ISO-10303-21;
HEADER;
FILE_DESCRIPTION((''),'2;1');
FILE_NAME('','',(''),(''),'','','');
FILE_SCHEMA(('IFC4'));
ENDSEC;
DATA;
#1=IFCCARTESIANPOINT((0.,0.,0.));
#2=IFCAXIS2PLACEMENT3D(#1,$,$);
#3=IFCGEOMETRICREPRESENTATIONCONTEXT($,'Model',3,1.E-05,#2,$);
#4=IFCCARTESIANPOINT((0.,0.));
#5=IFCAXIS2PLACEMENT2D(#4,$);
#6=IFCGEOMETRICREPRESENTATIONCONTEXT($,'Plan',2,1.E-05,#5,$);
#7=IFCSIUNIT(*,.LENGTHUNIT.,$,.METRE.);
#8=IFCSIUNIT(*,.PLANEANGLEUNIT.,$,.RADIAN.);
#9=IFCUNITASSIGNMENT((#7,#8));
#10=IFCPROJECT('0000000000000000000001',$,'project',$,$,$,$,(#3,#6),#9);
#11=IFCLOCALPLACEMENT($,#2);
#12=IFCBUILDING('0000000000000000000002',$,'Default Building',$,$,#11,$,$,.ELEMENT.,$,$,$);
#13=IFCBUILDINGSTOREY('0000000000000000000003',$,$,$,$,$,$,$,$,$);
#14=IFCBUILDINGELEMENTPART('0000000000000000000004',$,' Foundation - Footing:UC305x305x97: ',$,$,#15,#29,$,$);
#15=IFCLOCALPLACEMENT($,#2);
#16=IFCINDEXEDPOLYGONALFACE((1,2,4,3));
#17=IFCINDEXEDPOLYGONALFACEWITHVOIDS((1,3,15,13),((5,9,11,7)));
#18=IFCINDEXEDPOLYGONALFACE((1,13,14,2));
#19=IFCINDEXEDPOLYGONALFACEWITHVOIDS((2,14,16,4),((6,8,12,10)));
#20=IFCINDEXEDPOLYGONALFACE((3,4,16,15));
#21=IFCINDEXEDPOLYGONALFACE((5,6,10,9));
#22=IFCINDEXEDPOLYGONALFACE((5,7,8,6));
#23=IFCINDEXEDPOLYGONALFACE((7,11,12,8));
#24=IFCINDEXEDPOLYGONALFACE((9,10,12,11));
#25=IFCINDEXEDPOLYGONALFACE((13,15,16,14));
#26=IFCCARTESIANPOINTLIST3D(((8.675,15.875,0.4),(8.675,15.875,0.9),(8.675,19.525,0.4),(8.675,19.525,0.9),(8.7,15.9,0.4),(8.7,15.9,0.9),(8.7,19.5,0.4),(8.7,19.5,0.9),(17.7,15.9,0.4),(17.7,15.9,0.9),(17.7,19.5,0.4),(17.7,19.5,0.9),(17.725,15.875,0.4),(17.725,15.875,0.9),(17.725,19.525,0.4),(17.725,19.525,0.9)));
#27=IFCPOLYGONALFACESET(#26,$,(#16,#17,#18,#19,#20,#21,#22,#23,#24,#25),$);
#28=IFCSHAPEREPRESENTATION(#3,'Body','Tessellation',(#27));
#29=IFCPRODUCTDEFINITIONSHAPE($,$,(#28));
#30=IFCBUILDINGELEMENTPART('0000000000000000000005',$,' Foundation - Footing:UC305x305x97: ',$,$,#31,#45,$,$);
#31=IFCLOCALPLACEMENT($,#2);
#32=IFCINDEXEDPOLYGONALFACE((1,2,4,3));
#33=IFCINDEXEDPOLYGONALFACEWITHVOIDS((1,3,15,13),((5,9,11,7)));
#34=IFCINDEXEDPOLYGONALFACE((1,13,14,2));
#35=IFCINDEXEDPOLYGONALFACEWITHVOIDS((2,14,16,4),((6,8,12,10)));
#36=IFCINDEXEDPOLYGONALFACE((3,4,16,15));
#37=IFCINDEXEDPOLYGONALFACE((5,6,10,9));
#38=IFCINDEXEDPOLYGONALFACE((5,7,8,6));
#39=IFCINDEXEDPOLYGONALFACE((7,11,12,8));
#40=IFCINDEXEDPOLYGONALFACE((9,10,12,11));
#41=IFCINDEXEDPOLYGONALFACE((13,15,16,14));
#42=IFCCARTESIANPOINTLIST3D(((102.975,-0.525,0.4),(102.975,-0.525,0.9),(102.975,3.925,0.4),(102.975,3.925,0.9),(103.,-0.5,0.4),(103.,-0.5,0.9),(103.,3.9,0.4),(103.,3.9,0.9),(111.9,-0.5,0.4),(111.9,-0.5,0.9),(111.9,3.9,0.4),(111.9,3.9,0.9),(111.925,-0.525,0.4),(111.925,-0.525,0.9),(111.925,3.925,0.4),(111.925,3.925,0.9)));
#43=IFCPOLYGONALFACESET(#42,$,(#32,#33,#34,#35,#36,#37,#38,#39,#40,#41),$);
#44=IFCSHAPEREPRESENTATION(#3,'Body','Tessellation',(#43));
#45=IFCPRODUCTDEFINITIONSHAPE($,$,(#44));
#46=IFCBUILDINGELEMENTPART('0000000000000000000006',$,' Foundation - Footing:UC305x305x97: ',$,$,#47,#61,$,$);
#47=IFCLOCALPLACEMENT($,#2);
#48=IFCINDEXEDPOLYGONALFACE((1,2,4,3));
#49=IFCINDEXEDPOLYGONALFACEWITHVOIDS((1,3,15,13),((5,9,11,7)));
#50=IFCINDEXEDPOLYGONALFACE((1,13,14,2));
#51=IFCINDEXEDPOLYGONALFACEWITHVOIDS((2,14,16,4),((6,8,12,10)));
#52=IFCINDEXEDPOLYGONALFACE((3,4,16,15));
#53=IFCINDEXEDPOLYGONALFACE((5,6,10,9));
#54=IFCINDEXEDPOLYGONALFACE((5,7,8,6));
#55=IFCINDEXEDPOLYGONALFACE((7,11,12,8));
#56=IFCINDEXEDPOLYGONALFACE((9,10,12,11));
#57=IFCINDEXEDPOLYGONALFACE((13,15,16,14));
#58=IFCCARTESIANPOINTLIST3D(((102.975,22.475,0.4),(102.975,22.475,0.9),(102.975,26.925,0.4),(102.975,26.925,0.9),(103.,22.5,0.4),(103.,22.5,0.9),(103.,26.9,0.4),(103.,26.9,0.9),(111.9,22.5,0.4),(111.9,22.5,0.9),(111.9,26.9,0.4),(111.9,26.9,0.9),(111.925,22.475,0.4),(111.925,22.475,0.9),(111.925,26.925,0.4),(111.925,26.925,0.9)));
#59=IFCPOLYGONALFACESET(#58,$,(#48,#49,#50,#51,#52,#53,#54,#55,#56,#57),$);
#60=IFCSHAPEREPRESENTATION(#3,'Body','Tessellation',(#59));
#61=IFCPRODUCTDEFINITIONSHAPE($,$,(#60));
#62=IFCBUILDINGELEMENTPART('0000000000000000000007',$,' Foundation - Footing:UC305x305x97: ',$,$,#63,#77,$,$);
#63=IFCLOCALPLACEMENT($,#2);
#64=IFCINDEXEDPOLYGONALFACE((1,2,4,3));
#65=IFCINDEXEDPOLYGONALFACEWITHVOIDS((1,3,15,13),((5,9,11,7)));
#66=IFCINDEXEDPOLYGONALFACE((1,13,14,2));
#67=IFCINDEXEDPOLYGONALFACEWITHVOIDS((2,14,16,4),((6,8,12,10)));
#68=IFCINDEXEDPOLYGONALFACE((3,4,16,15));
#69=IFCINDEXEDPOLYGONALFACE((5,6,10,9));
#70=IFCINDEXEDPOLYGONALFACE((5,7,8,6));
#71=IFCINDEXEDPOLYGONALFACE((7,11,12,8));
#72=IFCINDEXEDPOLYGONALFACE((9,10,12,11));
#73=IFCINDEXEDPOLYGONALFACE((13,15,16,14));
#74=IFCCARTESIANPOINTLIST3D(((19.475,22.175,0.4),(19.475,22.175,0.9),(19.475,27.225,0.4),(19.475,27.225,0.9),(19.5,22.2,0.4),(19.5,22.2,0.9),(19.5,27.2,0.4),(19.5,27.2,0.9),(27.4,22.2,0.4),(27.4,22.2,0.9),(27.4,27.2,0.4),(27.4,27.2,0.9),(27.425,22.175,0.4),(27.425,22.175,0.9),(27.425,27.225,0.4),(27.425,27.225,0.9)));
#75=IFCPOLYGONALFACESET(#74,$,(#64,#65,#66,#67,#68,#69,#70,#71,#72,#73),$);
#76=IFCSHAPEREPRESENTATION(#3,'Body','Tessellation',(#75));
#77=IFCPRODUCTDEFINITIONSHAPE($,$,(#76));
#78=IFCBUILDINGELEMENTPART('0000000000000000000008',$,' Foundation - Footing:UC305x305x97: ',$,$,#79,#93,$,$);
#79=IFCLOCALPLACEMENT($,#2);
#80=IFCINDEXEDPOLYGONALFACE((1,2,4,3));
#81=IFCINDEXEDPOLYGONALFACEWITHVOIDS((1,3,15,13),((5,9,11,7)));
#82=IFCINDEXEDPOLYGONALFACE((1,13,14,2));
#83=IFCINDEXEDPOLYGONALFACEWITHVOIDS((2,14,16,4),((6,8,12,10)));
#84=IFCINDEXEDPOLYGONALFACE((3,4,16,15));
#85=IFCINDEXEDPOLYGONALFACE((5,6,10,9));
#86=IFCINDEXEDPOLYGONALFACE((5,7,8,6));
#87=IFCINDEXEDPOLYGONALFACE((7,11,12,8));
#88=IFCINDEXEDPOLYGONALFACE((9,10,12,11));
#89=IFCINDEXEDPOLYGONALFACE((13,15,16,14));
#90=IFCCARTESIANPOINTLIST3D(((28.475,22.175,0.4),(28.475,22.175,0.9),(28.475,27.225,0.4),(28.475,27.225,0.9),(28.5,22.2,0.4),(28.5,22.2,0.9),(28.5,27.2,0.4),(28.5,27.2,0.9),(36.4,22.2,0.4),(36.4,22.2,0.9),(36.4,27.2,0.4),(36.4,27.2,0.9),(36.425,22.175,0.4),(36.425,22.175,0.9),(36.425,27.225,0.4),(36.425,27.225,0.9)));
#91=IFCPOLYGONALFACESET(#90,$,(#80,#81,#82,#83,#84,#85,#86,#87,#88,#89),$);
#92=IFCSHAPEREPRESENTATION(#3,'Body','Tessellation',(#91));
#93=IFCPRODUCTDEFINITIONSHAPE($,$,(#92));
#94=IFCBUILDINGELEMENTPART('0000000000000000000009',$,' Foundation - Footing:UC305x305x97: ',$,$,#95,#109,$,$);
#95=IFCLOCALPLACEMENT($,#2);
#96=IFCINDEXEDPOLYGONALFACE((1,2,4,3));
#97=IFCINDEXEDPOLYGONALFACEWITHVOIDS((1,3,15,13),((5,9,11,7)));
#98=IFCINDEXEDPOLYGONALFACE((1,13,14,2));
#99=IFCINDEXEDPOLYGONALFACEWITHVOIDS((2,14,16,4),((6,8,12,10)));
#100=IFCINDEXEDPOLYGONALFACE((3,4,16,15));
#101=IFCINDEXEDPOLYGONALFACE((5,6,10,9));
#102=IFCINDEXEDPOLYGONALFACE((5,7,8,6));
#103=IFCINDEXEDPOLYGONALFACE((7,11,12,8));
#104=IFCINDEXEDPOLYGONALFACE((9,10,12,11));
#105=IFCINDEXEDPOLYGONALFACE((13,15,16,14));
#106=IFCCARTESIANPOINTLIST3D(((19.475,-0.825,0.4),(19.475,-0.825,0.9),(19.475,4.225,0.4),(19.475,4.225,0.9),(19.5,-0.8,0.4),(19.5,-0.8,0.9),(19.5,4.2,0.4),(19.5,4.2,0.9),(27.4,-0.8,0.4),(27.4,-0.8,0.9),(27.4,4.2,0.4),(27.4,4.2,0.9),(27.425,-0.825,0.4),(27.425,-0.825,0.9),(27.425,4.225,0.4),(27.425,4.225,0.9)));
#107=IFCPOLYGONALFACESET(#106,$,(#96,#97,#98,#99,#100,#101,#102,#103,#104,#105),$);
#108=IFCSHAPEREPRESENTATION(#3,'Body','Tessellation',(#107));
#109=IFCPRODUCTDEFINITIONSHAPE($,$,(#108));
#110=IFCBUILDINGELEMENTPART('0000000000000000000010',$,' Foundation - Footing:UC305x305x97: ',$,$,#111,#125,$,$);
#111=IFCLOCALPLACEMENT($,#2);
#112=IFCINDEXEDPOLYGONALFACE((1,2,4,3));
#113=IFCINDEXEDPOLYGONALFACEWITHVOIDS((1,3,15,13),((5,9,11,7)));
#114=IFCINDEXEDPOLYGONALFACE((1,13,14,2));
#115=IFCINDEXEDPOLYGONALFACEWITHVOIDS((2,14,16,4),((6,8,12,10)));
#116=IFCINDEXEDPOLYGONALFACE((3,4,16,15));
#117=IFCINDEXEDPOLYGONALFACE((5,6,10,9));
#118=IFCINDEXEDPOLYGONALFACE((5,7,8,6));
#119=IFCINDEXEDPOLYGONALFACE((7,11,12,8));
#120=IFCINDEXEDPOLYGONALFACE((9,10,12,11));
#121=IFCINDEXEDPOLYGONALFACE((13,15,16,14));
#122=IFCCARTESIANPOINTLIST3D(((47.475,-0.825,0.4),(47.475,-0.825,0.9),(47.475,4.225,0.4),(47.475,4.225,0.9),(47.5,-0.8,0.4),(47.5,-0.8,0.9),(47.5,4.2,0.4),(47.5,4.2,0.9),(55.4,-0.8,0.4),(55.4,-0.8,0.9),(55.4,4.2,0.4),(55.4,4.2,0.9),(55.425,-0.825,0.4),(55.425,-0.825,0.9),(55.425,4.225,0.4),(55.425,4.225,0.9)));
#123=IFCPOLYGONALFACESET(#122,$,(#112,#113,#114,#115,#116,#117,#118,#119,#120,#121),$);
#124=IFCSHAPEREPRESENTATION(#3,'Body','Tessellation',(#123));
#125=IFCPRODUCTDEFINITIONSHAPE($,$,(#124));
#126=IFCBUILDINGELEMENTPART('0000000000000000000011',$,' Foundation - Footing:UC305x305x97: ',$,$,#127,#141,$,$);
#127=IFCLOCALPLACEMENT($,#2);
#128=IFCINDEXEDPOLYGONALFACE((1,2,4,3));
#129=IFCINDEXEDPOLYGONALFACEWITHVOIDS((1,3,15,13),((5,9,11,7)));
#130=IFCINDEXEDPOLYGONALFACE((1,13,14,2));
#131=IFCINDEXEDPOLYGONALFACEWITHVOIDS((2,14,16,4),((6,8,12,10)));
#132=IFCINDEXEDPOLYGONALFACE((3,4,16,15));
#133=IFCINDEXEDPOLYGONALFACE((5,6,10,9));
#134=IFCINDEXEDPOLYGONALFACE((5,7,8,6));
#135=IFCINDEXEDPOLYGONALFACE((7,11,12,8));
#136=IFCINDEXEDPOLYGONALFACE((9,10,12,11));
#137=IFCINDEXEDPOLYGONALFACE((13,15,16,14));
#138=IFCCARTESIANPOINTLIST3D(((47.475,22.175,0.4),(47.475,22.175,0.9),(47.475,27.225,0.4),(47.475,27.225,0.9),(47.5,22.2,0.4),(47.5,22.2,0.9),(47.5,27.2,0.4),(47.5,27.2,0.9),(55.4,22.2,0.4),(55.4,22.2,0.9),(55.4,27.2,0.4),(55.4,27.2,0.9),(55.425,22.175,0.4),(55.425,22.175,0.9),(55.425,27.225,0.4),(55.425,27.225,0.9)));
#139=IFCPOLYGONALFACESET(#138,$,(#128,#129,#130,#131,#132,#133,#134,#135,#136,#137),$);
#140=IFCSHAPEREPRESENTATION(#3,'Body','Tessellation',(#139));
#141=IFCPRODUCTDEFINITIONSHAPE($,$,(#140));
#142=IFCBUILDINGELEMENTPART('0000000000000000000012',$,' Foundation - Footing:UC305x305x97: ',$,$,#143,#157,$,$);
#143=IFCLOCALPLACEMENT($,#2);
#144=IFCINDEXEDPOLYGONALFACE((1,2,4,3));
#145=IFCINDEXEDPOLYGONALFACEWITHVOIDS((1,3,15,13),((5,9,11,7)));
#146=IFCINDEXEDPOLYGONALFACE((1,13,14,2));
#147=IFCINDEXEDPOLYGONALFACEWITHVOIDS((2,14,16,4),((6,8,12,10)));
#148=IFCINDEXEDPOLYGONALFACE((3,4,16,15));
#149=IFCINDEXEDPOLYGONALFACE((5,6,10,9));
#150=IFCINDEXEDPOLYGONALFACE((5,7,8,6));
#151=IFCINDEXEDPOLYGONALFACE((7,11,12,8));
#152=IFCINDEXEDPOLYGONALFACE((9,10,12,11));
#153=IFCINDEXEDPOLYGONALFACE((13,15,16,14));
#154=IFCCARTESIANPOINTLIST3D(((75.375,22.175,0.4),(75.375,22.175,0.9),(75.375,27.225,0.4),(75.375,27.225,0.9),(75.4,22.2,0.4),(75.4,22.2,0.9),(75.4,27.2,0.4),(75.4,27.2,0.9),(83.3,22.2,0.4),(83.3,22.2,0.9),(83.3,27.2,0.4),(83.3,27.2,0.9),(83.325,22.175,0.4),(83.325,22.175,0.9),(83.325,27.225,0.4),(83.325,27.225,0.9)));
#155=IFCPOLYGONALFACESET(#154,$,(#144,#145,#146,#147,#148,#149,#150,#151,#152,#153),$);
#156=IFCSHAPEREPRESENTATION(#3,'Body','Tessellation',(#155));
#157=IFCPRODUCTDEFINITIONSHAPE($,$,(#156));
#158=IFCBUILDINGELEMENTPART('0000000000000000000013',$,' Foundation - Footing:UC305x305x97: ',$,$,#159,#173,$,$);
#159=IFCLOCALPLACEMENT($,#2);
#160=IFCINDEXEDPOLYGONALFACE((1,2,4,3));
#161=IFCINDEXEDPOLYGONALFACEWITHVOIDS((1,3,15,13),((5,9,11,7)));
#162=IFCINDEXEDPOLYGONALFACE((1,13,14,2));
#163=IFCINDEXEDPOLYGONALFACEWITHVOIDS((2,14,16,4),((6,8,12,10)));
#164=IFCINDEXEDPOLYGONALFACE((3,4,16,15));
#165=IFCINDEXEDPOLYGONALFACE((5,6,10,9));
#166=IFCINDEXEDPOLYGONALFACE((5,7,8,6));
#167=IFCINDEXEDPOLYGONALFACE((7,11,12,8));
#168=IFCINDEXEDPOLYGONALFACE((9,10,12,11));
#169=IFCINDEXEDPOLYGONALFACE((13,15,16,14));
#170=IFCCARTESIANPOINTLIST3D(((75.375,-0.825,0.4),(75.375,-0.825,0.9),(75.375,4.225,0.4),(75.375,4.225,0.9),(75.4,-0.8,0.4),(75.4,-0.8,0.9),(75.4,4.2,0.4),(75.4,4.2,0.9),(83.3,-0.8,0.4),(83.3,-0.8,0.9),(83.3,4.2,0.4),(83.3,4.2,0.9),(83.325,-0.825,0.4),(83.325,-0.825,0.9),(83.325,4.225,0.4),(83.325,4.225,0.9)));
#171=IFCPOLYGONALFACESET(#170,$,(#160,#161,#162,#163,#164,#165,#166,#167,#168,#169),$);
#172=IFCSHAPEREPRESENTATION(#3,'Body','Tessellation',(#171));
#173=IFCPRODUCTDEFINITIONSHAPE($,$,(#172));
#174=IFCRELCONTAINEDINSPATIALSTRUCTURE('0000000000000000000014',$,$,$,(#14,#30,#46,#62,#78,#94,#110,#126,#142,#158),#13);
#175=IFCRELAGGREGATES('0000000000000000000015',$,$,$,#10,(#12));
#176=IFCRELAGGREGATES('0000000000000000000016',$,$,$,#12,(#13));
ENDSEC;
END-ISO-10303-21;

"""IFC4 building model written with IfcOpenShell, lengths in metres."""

from ifc_helpers import new_model, si_unit, origin, origin_2d, place, context, project, spatial, polyline, outline, extrude, element, save


model = new_model("IFC4")

# Units and contexts
model_context = context("Model", 3, precision=1e-05, world=origin())
plan_context = context("Plan", 2, precision=1e-05, world=origin_2d())
ifc_project = project(units=[si_unit("LENGTHUNIT", "METRE"), si_unit("PLANEANGLEUNIT", "RADIAN")], contexts=[model_context, plan_context])

# Building, storey
building_placement = place(None, origin())
building = spatial("IfcBuilding", under=ifc_project, at=building_placement, Name="Default Building", CompositionType="ELEMENT")
storey = spatial("IfcBuildingStorey", under=building)

# Building element parts, openings
building_element_part_1 = element("IfcBuildingElementPart", 1, inside=storey, Name=" Foundation - Footing:UC305x305x97: ", context=model_context, shape_type="SweptSolid", body=[
    extrude(outline(polyline([(17.725, 19.525, 0.4), (8.675, 19.525, 0.4), (8.675, 15.875, 0.4), (17.725, 15.875, 0.4), (17.725, 19.525, 0.4)])), None, (0.0, 0.0, 1.0), 0.5),
])
element("IfcOpeningElement", 2, inside=storey, cuts=building_element_part_1, context=model_context, shape_type="SweptSolid", body=[
    extrude(outline(polyline([(17.7, 19.5, 0.4), (8.7, 19.5, 0.4), (8.7, 15.9, 0.4), (17.7, 15.9, 0.4), (17.7, 19.5, 0.4)])), None, (0.0, 0.0, 1.0), 0.5),
])
building_element_part_2 = element("IfcBuildingElementPart", 3, inside=storey, Name=" Foundation - Footing:UC305x305x97: ", context=model_context, shape_type="SweptSolid", body=[
    extrude(outline(polyline([(111.925, 3.925, 0.4), (102.975, 3.925, 0.4), (102.975, -0.525, 0.4), (111.925, -0.525, 0.4), (111.925, 3.925, 0.4)])), None, (0.0, 0.0, 1.0), 0.5),
])
element("IfcOpeningElement", 4, inside=storey, cuts=building_element_part_2, context=model_context, shape_type="SweptSolid", body=[
    extrude(outline(polyline([(111.9, 3.9, 0.4), (103.0, 3.9, 0.4), (103.0, -0.5, 0.4), (111.9, -0.5, 0.4), (111.9, 3.9, 0.4)])), None, (0.0, 0.0, 1.0), 0.5),
])
building_element_part_3 = element("IfcBuildingElementPart", 5, inside=storey, Name=" Foundation - Footing:UC305x305x97: ", context=model_context, shape_type="SweptSolid", body=[
    extrude(outline(polyline([(111.925, 26.925, 0.4), (102.975, 26.925, 0.4), (102.975, 22.475, 0.4), (111.925, 22.475, 0.4), (111.925, 26.925, 0.4)])), None, (0.0, 0.0, 1.0), 0.5),
])
element("IfcOpeningElement", 6, inside=storey, cuts=building_element_part_3, context=model_context, shape_type="SweptSolid", body=[
    extrude(outline(polyline([(111.9, 26.9, 0.4), (103.0, 26.9, 0.4), (103.0, 22.5, 0.4), (111.9, 22.5, 0.4), (111.9, 26.9, 0.4)])), None, (0.0, 0.0, 1.0), 0.5),
])
building_element_part_4 = element("IfcBuildingElementPart", 7, inside=storey, Name=" Foundation - Footing:UC305x305x97: ", context=model_context, shape_type="SweptSolid", body=[
    extrude(outline(polyline([(27.425, 27.225, 0.4), (19.475, 27.225, 0.4), (19.475, 22.175, 0.4), (27.425, 22.175, 0.4), (27.425, 27.225, 0.4)])), None, (0.0, 0.0, 1.0), 0.5),
])
element("IfcOpeningElement", 8, inside=storey, cuts=building_element_part_4, context=model_context, shape_type="SweptSolid", body=[
    extrude(outline(polyline([(27.4, 27.2, 0.4), (19.5, 27.2, 0.4), (19.5, 22.2, 0.4), (27.4, 22.2, 0.4), (27.4, 27.2, 0.4)])), None, (0.0, 0.0, 1.0), 0.5),
])
building_element_part_5 = element("IfcBuildingElementPart", 9, inside=storey, Name=" Foundation - Footing:UC305x305x97: ", context=model_context, shape_type="SweptSolid", body=[
    extrude(outline(polyline([(36.425, 27.225, 0.4), (28.475, 27.225, 0.4), (28.475, 22.175, 0.4), (36.425, 22.175, 0.4), (36.425, 27.225, 0.4)])), None, (0.0, 0.0, 1.0), 0.5),
])
element("IfcOpeningElement", 10, inside=storey, cuts=building_element_part_5, context=model_context, shape_type="SweptSolid", body=[
    extrude(outline(polyline([(36.4, 27.2, 0.4), (28.5, 27.2, 0.4), (28.5, 22.2, 0.4), (36.4, 22.2, 0.4), (36.4, 27.2, 0.4)])), None, (0.0, 0.0, 1.0), 0.5),
])
building_element_part_6 = element("IfcBuildingElementPart", 11, inside=storey, Name=" Foundation - Footing:UC305x305x97: ", context=model_context, shape_type="SweptSolid", body=[
    extrude(outline(polyline([(27.425, 4.225, 0.4), (19.475, 4.225, 0.4), (19.475, -0.825, 0.4), (27.425, -0.825, 0.4), (27.425, 4.225, 0.4)])), None, (0.0, 0.0, 1.0), 0.5),
])
element("IfcOpeningElement", 12, inside=storey, cuts=building_element_part_6, context=model_context, shape_type="SweptSolid", body=[
    extrude(outline(polyline([(27.4, 4.2, 0.4), (19.5, 4.2, 0.4), (19.5, -0.8, 0.4), (27.4, -0.8, 0.4), (27.4, 4.2, 0.4)])), None, (0.0, 0.0, 1.0), 0.5),
])
building_element_part_7 = element("IfcBuildingElementPart", 13, inside=storey, Name=" Foundation - Footing:UC305x305x97: ", context=model_context, shape_type="SweptSolid", body=[
    extrude(outline(polyline([(55.425, 4.225, 0.4), (47.475, 4.225, 0.4), (47.475, -0.825, 0.4), (55.425, -0.825, 0.4), (55.425, 4.225, 0.4)])), None, (0.0, 0.0, 1.0), 0.5),
])
element("IfcOpeningElement", 14, inside=storey, cuts=building_element_part_7, context=model_context, shape_type="SweptSolid", body=[
    extrude(outline(polyline([(55.4, 4.2, 0.4), (47.5, 4.2, 0.4), (47.5, -0.8, 0.4), (55.4, -0.8, 0.4), (55.4, 4.2, 0.4)])), None, (0.0, 0.0, 1.0), 0.5),
])
building_element_part_8 = element("IfcBuildingElementPart", 15, inside=storey, Name=" Foundation - Footing:UC305x305x97: ", context=model_context, shape_type="SweptSolid", body=[
    extrude(outline(polyline([(55.425, 27.225, 0.4), (47.475, 27.225, 0.4), (47.475, 22.175, 0.4), (55.425, 22.175, 0.4), (55.425, 27.225, 0.4)])), None, (0.0, 0.0, 1.0), 0.5),
])
element("IfcOpeningElement", 16, inside=storey, cuts=building_element_part_8, context=model_context, shape_type="SweptSolid", body=[
    extrude(outline(polyline([(55.4, 27.2, 0.4), (47.5, 27.2, 0.4), (47.5, 22.2, 0.4), (55.4, 22.2, 0.4), (55.4, 27.2, 0.4)])), None, (0.0, 0.0, 1.0), 0.5),
])
building_element_part_9 = element("IfcBuildingElementPart", 17, inside=storey, Name=" Foundation - Footing:UC305x305x97: ", context=model_context, shape_type="SweptSolid", body=[
    extrude(outline(polyline([(83.325, 27.225, 0.4), (75.375, 27.225, 0.4), (75.375, 22.175, 0.4), (83.325, 22.175, 0.4), (83.325, 27.225, 0.4)])), None, (0.0, 0.0, 1.0), 0.5),
])
element("IfcOpeningElement", 18, inside=storey, cuts=building_element_part_9, context=model_context, shape_type="SweptSolid", body=[
    extrude(outline(polyline([(83.3, 27.2, 0.4), (75.4, 27.2, 0.4), (75.4, 22.2, 0.4), (83.3, 22.2, 0.4), (83.3, 27.2, 0.4)])), None, (0.0, 0.0, 1.0), 0.5),
])
building_element_part_10 = element("IfcBuildingElementPart", 19, inside=storey, Name=" Foundation - Footing:UC305x305x97: ", context=model_context, shape_type="SweptSolid", body=[
    extrude(outline(polyline([(83.325, 4.225, 0.4), (75.375, 4.225, 0.4), (75.375, -0.825, 0.4), (83.325, -0.825, 0.4), (83.325, 4.225, 0.4)])), None, (0.0, 0.0, 1.0), 0.5),
])
element("IfcOpeningElement", 20, inside=storey, cuts=building_element_part_10, context=model_context, shape_type="SweptSolid", body=[
    extrude(outline(polyline([(83.3, 4.2, 0.4), (75.4, 4.2, 0.4), (75.4, -0.8, 0.4), (83.3, -0.8, 0.4), (83.3, 4.2, 0.4)])), None, (0.0, 0.0, 1.0), 0.5),
])

save(model, "model.ifc")
